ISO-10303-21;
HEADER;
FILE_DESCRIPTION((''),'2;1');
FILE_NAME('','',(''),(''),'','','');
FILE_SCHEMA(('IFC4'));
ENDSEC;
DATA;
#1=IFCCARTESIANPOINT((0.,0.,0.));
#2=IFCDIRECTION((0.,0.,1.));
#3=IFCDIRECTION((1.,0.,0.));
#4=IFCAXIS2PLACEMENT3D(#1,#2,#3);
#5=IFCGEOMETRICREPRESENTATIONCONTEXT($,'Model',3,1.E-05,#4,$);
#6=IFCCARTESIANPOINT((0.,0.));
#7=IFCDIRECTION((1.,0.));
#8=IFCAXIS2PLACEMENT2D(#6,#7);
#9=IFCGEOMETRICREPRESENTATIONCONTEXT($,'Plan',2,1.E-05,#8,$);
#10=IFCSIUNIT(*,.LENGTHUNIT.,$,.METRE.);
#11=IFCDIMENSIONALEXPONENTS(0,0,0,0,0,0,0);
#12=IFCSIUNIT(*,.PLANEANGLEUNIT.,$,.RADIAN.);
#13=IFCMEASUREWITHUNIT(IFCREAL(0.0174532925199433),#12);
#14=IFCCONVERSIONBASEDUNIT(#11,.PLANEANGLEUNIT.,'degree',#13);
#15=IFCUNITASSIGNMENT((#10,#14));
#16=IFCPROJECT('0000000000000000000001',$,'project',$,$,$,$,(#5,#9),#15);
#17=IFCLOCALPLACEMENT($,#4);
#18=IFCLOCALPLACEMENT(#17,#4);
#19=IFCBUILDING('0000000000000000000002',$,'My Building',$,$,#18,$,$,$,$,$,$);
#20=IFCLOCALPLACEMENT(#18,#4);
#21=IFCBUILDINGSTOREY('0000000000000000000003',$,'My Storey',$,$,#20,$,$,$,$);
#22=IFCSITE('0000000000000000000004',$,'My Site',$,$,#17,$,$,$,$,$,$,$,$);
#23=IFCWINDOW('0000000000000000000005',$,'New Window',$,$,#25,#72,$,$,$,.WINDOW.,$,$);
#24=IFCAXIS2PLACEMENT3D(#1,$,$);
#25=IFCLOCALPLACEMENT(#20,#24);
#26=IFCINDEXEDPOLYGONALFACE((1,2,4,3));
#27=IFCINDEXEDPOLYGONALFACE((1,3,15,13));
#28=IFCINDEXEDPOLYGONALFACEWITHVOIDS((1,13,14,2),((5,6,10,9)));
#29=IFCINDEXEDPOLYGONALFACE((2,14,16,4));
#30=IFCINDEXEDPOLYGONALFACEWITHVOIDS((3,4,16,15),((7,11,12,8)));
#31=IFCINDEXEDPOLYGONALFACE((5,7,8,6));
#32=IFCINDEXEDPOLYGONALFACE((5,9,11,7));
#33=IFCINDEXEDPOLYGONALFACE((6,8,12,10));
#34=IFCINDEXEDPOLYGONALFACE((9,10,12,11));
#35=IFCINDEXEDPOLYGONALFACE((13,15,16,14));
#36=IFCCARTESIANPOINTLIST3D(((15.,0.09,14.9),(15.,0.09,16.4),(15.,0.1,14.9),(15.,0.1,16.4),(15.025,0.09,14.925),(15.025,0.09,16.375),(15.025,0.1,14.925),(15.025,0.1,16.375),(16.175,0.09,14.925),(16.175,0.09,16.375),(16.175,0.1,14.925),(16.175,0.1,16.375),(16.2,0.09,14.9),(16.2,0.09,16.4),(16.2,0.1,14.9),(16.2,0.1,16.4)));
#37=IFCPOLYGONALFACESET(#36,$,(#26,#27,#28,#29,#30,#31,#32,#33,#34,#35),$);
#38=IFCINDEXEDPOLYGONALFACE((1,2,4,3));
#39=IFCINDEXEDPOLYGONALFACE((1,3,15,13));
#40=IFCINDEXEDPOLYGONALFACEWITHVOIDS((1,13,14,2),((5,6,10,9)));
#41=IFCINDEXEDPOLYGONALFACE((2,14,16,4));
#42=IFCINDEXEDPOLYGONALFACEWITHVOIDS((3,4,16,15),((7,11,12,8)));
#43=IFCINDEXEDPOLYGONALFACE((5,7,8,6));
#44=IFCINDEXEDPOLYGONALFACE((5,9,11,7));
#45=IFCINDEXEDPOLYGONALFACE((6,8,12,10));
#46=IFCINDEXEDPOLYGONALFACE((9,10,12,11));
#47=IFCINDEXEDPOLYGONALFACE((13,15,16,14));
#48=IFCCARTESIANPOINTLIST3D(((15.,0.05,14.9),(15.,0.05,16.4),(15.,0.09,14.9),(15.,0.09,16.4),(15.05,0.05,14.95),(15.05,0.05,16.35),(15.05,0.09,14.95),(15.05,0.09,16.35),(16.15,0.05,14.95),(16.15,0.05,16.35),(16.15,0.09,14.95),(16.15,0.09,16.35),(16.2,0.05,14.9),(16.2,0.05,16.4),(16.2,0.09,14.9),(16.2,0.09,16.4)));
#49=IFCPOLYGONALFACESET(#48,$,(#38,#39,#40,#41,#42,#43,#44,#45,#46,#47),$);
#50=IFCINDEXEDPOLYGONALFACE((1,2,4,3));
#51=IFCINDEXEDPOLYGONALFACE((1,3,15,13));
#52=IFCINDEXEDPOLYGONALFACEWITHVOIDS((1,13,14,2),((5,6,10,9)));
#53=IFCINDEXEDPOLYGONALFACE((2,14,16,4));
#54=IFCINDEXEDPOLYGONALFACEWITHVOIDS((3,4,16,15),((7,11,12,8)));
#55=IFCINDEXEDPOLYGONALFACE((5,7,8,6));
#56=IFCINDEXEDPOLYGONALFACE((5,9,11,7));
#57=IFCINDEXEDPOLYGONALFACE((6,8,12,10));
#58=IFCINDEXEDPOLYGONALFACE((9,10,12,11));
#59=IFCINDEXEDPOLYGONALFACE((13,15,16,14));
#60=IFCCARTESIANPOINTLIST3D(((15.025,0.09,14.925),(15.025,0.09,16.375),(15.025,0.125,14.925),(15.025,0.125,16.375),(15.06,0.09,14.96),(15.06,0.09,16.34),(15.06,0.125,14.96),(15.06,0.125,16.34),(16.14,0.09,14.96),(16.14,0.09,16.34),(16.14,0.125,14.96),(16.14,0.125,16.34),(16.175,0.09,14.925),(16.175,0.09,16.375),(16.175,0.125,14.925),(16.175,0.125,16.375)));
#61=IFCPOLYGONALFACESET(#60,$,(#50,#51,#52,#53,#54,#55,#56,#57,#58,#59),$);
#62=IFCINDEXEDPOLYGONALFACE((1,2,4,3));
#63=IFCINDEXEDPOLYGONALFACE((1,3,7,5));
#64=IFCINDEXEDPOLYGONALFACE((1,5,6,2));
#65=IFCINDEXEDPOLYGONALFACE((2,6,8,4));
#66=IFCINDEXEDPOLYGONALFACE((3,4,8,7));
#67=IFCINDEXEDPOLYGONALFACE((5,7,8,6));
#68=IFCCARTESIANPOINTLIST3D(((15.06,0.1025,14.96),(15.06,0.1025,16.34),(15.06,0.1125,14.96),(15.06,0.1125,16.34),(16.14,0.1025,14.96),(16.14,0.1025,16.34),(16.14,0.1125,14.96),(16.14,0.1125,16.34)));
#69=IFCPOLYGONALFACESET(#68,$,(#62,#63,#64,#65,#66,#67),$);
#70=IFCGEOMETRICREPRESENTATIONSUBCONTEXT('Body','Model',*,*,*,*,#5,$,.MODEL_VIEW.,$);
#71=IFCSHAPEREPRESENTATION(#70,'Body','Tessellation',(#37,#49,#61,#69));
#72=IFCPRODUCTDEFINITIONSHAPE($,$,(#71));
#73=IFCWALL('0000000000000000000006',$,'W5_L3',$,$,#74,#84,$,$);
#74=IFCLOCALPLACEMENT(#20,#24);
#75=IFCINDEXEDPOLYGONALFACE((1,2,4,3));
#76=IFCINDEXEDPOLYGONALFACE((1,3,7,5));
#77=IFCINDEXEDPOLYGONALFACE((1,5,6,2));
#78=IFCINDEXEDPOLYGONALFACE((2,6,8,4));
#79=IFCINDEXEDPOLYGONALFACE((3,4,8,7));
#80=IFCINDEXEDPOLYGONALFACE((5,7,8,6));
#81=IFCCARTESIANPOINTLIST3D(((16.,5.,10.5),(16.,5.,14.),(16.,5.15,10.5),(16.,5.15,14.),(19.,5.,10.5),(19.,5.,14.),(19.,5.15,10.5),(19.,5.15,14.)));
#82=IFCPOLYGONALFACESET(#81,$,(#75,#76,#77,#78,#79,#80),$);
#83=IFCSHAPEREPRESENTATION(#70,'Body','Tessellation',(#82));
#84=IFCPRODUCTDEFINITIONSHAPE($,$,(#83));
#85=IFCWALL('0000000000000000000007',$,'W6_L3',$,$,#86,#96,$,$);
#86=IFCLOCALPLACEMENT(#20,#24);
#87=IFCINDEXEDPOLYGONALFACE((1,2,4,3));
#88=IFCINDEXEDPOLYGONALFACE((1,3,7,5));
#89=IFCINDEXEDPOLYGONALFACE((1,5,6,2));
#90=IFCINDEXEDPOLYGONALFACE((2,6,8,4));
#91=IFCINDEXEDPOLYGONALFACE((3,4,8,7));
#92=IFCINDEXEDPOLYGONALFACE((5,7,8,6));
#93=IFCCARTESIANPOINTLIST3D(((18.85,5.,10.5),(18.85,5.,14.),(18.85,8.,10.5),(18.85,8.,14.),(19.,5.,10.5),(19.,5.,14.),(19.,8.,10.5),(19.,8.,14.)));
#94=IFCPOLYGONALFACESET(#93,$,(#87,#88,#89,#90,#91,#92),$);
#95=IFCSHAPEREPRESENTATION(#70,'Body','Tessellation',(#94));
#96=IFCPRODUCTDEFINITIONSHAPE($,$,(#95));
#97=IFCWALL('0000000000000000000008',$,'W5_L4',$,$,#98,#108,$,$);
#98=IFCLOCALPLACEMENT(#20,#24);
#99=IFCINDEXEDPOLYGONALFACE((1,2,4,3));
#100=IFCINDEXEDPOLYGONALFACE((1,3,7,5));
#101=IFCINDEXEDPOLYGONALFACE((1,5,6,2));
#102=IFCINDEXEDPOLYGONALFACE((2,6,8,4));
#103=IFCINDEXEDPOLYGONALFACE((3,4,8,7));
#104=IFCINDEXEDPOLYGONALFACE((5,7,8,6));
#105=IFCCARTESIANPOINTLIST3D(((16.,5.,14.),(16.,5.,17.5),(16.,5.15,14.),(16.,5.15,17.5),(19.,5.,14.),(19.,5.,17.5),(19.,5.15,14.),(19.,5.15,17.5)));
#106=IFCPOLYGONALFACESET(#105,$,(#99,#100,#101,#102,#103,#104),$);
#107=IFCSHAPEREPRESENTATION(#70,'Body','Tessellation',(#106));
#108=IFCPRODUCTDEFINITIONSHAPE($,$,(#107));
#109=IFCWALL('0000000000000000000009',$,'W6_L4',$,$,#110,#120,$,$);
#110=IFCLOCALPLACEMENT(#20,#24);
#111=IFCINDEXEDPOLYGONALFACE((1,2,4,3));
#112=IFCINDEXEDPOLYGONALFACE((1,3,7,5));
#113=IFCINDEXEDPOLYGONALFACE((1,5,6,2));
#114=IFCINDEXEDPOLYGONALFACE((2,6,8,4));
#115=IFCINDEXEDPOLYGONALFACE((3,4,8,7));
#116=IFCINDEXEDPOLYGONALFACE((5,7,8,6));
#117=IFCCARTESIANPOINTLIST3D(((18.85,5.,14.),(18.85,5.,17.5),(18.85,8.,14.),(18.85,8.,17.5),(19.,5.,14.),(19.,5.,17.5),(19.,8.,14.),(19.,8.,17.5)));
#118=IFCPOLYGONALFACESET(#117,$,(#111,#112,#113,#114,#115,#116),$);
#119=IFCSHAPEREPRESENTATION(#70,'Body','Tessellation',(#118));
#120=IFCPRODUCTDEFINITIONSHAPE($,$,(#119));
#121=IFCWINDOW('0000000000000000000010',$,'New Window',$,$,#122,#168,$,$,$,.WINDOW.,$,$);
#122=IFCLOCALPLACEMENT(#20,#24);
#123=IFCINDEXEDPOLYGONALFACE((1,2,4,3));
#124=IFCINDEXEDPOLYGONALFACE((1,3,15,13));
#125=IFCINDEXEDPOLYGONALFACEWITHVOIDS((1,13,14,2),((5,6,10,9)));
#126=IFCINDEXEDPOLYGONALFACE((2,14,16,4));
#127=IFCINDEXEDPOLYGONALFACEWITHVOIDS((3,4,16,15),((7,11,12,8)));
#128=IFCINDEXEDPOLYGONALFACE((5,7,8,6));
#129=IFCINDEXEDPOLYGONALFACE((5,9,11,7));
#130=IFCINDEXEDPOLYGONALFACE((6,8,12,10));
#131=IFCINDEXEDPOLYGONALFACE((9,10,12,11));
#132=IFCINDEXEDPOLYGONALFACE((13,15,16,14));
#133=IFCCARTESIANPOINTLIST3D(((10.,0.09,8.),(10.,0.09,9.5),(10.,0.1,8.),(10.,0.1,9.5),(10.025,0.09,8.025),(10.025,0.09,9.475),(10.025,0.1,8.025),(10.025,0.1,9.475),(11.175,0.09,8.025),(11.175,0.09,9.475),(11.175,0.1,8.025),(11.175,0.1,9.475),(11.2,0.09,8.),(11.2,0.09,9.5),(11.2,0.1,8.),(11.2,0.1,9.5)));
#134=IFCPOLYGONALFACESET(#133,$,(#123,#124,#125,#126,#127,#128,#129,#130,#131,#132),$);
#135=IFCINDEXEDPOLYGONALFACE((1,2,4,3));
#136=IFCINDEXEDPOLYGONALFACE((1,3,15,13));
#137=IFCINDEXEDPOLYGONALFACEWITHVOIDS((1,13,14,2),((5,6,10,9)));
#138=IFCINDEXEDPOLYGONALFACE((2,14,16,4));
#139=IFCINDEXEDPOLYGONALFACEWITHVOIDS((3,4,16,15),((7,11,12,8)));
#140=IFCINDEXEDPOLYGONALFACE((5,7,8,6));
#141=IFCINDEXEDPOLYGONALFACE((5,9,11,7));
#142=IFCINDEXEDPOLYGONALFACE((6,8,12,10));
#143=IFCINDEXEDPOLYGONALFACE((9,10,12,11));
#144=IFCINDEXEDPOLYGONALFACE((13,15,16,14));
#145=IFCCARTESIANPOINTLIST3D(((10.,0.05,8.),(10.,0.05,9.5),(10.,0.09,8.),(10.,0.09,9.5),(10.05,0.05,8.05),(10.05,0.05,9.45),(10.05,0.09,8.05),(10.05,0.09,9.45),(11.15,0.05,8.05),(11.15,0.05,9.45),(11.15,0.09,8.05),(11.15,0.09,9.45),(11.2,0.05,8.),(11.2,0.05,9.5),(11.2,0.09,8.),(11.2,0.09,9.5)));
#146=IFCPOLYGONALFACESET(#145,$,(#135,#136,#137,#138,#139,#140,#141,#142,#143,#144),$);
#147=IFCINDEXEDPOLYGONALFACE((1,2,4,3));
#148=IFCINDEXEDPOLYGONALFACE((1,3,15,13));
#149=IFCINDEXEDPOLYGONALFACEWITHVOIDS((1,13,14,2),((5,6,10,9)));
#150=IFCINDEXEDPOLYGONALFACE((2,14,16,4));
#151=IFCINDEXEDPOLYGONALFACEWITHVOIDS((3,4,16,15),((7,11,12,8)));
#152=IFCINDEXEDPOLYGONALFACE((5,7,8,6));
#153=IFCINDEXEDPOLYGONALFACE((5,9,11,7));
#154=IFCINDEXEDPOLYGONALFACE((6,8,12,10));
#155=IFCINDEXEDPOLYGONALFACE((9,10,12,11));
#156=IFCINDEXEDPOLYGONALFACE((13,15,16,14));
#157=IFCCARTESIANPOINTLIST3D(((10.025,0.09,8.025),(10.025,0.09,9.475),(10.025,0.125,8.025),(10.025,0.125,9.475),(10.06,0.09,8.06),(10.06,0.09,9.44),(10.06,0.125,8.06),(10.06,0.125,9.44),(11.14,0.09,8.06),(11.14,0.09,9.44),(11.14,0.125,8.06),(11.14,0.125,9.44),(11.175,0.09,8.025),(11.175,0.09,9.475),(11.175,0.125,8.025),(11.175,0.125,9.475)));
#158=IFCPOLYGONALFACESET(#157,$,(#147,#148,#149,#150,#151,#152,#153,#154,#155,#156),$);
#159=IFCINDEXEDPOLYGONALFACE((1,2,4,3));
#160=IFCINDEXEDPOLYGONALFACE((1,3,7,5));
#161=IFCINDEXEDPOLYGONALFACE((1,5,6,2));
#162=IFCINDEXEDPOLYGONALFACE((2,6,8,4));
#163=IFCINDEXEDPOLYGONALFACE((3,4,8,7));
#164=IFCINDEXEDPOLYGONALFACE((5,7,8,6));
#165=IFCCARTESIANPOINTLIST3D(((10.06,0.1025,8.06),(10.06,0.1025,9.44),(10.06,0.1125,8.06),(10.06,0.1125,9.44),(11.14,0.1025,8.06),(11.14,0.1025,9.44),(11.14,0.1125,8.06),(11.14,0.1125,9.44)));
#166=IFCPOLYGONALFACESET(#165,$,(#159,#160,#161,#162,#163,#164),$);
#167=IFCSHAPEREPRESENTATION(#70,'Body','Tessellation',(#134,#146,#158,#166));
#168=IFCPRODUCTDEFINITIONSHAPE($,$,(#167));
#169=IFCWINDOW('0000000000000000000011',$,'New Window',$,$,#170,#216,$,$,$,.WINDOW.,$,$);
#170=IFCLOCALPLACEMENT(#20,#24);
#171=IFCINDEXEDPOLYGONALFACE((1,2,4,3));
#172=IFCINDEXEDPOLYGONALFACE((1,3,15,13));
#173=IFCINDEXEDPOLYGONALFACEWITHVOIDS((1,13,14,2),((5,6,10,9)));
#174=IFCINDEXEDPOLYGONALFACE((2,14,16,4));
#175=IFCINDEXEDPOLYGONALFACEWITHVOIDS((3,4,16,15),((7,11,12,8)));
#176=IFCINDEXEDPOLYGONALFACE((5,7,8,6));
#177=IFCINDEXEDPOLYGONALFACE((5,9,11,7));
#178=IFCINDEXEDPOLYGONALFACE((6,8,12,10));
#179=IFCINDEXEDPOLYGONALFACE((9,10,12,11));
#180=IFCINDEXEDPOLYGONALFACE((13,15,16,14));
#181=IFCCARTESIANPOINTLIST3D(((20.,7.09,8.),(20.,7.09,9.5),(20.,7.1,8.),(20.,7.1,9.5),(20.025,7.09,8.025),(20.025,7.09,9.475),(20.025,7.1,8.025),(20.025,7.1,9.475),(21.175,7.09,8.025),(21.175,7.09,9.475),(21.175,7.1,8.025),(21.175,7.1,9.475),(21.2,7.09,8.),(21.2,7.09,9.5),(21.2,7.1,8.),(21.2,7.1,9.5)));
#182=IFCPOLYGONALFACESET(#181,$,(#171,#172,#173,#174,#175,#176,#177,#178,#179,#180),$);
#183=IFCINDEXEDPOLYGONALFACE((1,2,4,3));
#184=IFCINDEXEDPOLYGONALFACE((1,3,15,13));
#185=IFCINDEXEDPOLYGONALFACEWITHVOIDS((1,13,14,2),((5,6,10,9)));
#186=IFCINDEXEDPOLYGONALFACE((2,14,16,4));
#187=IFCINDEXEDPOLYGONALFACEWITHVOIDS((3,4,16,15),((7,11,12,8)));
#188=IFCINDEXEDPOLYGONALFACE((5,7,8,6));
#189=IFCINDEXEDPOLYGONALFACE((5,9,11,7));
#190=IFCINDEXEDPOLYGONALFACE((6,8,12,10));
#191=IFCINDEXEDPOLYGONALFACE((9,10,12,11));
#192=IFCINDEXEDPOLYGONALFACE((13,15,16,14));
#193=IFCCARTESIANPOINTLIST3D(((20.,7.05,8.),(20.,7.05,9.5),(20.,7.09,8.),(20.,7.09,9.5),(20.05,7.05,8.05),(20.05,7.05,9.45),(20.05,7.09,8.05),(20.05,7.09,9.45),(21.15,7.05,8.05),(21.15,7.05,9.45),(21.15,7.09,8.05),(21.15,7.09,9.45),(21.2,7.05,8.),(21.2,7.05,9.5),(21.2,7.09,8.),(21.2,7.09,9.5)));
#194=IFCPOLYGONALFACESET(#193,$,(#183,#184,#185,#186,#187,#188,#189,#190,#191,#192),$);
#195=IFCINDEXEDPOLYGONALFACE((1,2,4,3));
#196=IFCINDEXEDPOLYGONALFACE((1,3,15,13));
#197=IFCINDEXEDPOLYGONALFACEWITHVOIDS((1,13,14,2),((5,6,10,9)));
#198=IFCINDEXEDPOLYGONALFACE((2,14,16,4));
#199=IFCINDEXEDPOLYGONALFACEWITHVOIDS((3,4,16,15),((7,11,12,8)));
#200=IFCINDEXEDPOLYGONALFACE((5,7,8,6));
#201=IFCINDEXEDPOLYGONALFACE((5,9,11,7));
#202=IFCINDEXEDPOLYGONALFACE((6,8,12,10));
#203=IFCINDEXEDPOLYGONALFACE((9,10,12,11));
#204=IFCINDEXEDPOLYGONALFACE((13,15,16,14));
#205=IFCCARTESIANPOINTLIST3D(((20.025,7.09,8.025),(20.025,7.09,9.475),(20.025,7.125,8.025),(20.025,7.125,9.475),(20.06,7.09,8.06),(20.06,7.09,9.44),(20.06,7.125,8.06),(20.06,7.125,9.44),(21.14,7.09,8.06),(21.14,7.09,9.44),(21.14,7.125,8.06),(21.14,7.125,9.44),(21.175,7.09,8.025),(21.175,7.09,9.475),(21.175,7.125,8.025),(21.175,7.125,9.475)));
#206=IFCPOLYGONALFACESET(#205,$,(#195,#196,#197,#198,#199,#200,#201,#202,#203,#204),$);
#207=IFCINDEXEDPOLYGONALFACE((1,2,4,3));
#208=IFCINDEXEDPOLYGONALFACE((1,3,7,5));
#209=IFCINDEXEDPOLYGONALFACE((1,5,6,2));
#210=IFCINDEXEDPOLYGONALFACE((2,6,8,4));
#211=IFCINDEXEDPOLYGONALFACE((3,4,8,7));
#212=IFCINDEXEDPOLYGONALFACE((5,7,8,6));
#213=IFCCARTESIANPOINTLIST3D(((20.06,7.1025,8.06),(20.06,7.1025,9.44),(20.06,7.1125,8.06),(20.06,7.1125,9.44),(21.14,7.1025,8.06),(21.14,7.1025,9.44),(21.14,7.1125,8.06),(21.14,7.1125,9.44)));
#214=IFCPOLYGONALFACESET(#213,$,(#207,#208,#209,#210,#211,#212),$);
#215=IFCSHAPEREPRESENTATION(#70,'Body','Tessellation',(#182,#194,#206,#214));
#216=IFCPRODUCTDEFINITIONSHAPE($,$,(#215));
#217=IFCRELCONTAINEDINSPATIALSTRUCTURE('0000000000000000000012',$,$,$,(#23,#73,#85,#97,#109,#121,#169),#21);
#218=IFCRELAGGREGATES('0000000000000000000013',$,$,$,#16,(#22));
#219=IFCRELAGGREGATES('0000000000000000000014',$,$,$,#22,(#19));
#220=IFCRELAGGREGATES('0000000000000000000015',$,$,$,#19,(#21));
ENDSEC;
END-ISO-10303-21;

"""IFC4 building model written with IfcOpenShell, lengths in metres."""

from ifc_helpers import new_model, entity, si_unit, converted_unit, frame, origin_with_axes, origin_2d_with_axis, place, context, subcontext, project, spatial, line, indexed_curve, outline, extrude, element, save


model = new_model("IFC4")

# Units and contexts
model_context = context("Model", 3, precision=1e-05, world=origin_with_axes())
plan_context = context("Plan", 2, precision=1e-05, world=origin_2d_with_axis())
body_context = subcontext(model_context, "Body", "Model", "MODEL_VIEW")
ifc_project = project(units=[si_unit("LENGTHUNIT", "METRE"), converted_unit("PLANEANGLEUNIT", "degree", entity("IfcReal", 0.0174532925199433), si_unit("PLANEANGLEUNIT", "RADIAN"), dimensions=[0, 0, 0, 0, 0, 0, 0])], contexts=[model_context, plan_context])

# Site, building, storey
site_placement = place(None, origin_with_axes())
site = spatial("IfcSite", under=ifc_project, at=site_placement, Name="My Site")
building_placement = place(site_placement, origin_with_axes())
building = spatial("IfcBuilding", under=site, at=building_placement, Name="My Building")
storey_placement = place(building_placement, origin_with_axes())
storey = spatial("IfcBuildingStorey", under=building, at=storey_placement, Name="My Storey")

# Window
for number, where, z_axis, x_axis, name in (
    (1, (15.0, 0.0, 14.9), (0.0, 0.0, 1.0), (1.0, 0.0, 0.0), "New Window"),
):
    element("IfcWindow", number, at=place(storey_placement, frame(where, z_axis=z_axis, x_axis=x_axis)), inside=storey, Name=name, PredefinedType="WINDOW", context=body_context, shape_type="SweptSolid", body=[
        extrude(outline(indexed_curve([(0.0, 0.0), (1.2, 0.0), (1.2, 1.5), (0.0, 1.5)], segments=[line(1, 2, 3, 4, 1)]), holes=[indexed_curve([(0.025, 0.025), (1.175, 0.025), (1.175, 1.475), (0.025, 1.475)], segments=[line(1, 2, 3, 4, 1)])]), frame((0.0, 0.09, 0.0), z_axis=(0.0, -1.0, 0.0), x_axis=(1.0, 0.0, 0.0)), (0.0, 0.0, -1.0), 0.01),
        extrude(outline(indexed_curve([(0.0, 0.0), (1.2, 0.0), (1.2, 1.5), (0.0, 1.5)], segments=[line(1, 2, 3, 4, 1)]), holes=[indexed_curve([(0.05, 0.05), (1.15, 0.05), (1.15, 1.45), (0.05, 1.45)], segments=[line(1, 2, 3, 4, 1)])]), frame((0.0, 0.05, 0.0), z_axis=(0.0, -1.0, 0.0), x_axis=(1.0, 0.0, 0.0)), (0.0, 0.0, -1.0), 0.04),
        extrude(outline(indexed_curve([(0.0, 0.0), (1.15, 0.0), (1.15, 1.45), (0.0, 1.45)], segments=[line(1, 2, 3, 4, 1)]), holes=[indexed_curve([(0.035, 0.035), (1.115, 0.035), (1.115, 1.415), (0.035, 1.415)], segments=[line(1, 2, 3, 4, 1)])]), frame((0.025, 0.09, 0.025), z_axis=(0.0, -1.0, 0.0), x_axis=(1.0, 0.0, 0.0)), (0.0, 0.0, -1.0), 0.035),
        extrude(outline(indexed_curve([(0.035, 0.035), (1.115, 0.035), (1.115, 1.415), (0.035, 1.415)], segments=[line(1, 2, 3, 4, 1)])), frame((0.025, 0.1025, 0.025), z_axis=(0.0, -1.0, 0.0), x_axis=(1.0, 0.0, 0.0)), (0.0, 0.0, -1.0), 0.01),
    ])

# Walls
for number, where, z_axis, x_axis, name in (
    (2, (16.0, 5.0, 10.5), (0.0, 0.0, 1.0), (1.0, 0.0, 0.0), "W5_L3"),
    (3, (19.0, 5.0, 10.5), (0.0, 0.0, 1.0), (0.0, 1.0, 0.0), "W6_L3"),
):
    element("IfcWall", number, at=place(storey_placement, frame(where, z_axis=z_axis, x_axis=x_axis)), inside=storey, Name=name, context=body_context, shape_type="SweptSolid", body=[
        extrude(outline(indexed_curve([(0.0, 0.0), (0.0, 0.15), (3.0, 0.15), (3.0, 0.0), (0.0, 0.0)], self_intersect=False)), origin_with_axes(), (0.0, 0.0, 1.0), 3.5),
    ])
for number, where, z_axis, x_axis, name in (
    (4, (16.0, 5.0, 14.0), (0.0, 0.0, 1.0), (1.0, 0.0, 0.0), "W5_L4"),
    (5, (19.0, 5.0, 14.0), (0.0, 0.0, 1.0), (0.0, 1.0, 0.0), "W6_L4"),
):
    element("IfcWall", number, at=place(storey_placement, frame(where, z_axis=z_axis, x_axis=x_axis)), inside=storey, Name=name, context=body_context, shape_type="SweptSolid", body=[
        extrude(outline(indexed_curve([(0.0, 0.0), (0.0, 0.15), (3.0, 0.15), (3.0, 0.0), (0.0, 0.0)], self_intersect=False)), origin_with_axes(), (0.0, 0.0, 1.0), 3.5),
    ])

# Windows
for number, where, z_axis, x_axis, name in (
    (6, (10.0, 0.0, 8.0), (0.0, 0.0, 1.0), (1.0, 0.0, 0.0), "New Window"),
    (7, (20.0, 7.0, 8.0), (0.0, 0.0, 1.0), (1.0, 0.0, 0.0), "New Window"),
):
    element("IfcWindow", number, at=place(storey_placement, frame(where, z_axis=z_axis, x_axis=x_axis)), inside=storey, Name=name, PredefinedType="WINDOW", context=body_context, shape_type="SweptSolid", body=[
        extrude(outline(indexed_curve([(0.0, 0.0), (1.2, 0.0), (1.2, 1.5), (0.0, 1.5)], segments=[line(1, 2, 3, 4, 1)]), holes=[indexed_curve([(0.025, 0.025), (1.175, 0.025), (1.175, 1.475), (0.025, 1.475)], segments=[line(1, 2, 3, 4, 1)])]), frame((0.0, 0.09, 0.0), z_axis=(0.0, -1.0, 0.0), x_axis=(1.0, 0.0, 0.0)), (0.0, 0.0, -1.0), 0.01),
        extrude(outline(indexed_curve([(0.0, 0.0), (1.2, 0.0), (1.2, 1.5), (0.0, 1.5)], segments=[line(1, 2, 3, 4, 1)]), holes=[indexed_curve([(0.05, 0.05), (1.15, 0.05), (1.15, 1.45), (0.05, 1.45)], segments=[line(1, 2, 3, 4, 1)])]), frame((0.0, 0.05, 0.0), z_axis=(0.0, -1.0, 0.0), x_axis=(1.0, 0.0, 0.0)), (0.0, 0.0, -1.0), 0.04),
        extrude(outline(indexed_curve([(0.0, 0.0), (1.15, 0.0), (1.15, 1.45), (0.0, 1.45)], segments=[line(1, 2, 3, 4, 1)]), holes=[indexed_curve([(0.035, 0.035), (1.115, 0.035), (1.115, 1.415), (0.035, 1.415)], segments=[line(1, 2, 3, 4, 1)])]), frame((0.025, 0.09, 0.025), z_axis=(0.0, -1.0, 0.0), x_axis=(1.0, 0.0, 0.0)), (0.0, 0.0, -1.0), 0.035),
        extrude(outline(indexed_curve([(0.035, 0.035), (1.115, 0.035), (1.115, 1.415), (0.035, 1.415)], segments=[line(1, 2, 3, 4, 1)])), frame((0.025, 0.1025, 0.025), z_axis=(0.0, -1.0, 0.0), x_axis=(1.0, 0.0, 0.0)), (0.0, 0.0, -1.0), 0.01),
    ])

save(model, "model.ifc")
